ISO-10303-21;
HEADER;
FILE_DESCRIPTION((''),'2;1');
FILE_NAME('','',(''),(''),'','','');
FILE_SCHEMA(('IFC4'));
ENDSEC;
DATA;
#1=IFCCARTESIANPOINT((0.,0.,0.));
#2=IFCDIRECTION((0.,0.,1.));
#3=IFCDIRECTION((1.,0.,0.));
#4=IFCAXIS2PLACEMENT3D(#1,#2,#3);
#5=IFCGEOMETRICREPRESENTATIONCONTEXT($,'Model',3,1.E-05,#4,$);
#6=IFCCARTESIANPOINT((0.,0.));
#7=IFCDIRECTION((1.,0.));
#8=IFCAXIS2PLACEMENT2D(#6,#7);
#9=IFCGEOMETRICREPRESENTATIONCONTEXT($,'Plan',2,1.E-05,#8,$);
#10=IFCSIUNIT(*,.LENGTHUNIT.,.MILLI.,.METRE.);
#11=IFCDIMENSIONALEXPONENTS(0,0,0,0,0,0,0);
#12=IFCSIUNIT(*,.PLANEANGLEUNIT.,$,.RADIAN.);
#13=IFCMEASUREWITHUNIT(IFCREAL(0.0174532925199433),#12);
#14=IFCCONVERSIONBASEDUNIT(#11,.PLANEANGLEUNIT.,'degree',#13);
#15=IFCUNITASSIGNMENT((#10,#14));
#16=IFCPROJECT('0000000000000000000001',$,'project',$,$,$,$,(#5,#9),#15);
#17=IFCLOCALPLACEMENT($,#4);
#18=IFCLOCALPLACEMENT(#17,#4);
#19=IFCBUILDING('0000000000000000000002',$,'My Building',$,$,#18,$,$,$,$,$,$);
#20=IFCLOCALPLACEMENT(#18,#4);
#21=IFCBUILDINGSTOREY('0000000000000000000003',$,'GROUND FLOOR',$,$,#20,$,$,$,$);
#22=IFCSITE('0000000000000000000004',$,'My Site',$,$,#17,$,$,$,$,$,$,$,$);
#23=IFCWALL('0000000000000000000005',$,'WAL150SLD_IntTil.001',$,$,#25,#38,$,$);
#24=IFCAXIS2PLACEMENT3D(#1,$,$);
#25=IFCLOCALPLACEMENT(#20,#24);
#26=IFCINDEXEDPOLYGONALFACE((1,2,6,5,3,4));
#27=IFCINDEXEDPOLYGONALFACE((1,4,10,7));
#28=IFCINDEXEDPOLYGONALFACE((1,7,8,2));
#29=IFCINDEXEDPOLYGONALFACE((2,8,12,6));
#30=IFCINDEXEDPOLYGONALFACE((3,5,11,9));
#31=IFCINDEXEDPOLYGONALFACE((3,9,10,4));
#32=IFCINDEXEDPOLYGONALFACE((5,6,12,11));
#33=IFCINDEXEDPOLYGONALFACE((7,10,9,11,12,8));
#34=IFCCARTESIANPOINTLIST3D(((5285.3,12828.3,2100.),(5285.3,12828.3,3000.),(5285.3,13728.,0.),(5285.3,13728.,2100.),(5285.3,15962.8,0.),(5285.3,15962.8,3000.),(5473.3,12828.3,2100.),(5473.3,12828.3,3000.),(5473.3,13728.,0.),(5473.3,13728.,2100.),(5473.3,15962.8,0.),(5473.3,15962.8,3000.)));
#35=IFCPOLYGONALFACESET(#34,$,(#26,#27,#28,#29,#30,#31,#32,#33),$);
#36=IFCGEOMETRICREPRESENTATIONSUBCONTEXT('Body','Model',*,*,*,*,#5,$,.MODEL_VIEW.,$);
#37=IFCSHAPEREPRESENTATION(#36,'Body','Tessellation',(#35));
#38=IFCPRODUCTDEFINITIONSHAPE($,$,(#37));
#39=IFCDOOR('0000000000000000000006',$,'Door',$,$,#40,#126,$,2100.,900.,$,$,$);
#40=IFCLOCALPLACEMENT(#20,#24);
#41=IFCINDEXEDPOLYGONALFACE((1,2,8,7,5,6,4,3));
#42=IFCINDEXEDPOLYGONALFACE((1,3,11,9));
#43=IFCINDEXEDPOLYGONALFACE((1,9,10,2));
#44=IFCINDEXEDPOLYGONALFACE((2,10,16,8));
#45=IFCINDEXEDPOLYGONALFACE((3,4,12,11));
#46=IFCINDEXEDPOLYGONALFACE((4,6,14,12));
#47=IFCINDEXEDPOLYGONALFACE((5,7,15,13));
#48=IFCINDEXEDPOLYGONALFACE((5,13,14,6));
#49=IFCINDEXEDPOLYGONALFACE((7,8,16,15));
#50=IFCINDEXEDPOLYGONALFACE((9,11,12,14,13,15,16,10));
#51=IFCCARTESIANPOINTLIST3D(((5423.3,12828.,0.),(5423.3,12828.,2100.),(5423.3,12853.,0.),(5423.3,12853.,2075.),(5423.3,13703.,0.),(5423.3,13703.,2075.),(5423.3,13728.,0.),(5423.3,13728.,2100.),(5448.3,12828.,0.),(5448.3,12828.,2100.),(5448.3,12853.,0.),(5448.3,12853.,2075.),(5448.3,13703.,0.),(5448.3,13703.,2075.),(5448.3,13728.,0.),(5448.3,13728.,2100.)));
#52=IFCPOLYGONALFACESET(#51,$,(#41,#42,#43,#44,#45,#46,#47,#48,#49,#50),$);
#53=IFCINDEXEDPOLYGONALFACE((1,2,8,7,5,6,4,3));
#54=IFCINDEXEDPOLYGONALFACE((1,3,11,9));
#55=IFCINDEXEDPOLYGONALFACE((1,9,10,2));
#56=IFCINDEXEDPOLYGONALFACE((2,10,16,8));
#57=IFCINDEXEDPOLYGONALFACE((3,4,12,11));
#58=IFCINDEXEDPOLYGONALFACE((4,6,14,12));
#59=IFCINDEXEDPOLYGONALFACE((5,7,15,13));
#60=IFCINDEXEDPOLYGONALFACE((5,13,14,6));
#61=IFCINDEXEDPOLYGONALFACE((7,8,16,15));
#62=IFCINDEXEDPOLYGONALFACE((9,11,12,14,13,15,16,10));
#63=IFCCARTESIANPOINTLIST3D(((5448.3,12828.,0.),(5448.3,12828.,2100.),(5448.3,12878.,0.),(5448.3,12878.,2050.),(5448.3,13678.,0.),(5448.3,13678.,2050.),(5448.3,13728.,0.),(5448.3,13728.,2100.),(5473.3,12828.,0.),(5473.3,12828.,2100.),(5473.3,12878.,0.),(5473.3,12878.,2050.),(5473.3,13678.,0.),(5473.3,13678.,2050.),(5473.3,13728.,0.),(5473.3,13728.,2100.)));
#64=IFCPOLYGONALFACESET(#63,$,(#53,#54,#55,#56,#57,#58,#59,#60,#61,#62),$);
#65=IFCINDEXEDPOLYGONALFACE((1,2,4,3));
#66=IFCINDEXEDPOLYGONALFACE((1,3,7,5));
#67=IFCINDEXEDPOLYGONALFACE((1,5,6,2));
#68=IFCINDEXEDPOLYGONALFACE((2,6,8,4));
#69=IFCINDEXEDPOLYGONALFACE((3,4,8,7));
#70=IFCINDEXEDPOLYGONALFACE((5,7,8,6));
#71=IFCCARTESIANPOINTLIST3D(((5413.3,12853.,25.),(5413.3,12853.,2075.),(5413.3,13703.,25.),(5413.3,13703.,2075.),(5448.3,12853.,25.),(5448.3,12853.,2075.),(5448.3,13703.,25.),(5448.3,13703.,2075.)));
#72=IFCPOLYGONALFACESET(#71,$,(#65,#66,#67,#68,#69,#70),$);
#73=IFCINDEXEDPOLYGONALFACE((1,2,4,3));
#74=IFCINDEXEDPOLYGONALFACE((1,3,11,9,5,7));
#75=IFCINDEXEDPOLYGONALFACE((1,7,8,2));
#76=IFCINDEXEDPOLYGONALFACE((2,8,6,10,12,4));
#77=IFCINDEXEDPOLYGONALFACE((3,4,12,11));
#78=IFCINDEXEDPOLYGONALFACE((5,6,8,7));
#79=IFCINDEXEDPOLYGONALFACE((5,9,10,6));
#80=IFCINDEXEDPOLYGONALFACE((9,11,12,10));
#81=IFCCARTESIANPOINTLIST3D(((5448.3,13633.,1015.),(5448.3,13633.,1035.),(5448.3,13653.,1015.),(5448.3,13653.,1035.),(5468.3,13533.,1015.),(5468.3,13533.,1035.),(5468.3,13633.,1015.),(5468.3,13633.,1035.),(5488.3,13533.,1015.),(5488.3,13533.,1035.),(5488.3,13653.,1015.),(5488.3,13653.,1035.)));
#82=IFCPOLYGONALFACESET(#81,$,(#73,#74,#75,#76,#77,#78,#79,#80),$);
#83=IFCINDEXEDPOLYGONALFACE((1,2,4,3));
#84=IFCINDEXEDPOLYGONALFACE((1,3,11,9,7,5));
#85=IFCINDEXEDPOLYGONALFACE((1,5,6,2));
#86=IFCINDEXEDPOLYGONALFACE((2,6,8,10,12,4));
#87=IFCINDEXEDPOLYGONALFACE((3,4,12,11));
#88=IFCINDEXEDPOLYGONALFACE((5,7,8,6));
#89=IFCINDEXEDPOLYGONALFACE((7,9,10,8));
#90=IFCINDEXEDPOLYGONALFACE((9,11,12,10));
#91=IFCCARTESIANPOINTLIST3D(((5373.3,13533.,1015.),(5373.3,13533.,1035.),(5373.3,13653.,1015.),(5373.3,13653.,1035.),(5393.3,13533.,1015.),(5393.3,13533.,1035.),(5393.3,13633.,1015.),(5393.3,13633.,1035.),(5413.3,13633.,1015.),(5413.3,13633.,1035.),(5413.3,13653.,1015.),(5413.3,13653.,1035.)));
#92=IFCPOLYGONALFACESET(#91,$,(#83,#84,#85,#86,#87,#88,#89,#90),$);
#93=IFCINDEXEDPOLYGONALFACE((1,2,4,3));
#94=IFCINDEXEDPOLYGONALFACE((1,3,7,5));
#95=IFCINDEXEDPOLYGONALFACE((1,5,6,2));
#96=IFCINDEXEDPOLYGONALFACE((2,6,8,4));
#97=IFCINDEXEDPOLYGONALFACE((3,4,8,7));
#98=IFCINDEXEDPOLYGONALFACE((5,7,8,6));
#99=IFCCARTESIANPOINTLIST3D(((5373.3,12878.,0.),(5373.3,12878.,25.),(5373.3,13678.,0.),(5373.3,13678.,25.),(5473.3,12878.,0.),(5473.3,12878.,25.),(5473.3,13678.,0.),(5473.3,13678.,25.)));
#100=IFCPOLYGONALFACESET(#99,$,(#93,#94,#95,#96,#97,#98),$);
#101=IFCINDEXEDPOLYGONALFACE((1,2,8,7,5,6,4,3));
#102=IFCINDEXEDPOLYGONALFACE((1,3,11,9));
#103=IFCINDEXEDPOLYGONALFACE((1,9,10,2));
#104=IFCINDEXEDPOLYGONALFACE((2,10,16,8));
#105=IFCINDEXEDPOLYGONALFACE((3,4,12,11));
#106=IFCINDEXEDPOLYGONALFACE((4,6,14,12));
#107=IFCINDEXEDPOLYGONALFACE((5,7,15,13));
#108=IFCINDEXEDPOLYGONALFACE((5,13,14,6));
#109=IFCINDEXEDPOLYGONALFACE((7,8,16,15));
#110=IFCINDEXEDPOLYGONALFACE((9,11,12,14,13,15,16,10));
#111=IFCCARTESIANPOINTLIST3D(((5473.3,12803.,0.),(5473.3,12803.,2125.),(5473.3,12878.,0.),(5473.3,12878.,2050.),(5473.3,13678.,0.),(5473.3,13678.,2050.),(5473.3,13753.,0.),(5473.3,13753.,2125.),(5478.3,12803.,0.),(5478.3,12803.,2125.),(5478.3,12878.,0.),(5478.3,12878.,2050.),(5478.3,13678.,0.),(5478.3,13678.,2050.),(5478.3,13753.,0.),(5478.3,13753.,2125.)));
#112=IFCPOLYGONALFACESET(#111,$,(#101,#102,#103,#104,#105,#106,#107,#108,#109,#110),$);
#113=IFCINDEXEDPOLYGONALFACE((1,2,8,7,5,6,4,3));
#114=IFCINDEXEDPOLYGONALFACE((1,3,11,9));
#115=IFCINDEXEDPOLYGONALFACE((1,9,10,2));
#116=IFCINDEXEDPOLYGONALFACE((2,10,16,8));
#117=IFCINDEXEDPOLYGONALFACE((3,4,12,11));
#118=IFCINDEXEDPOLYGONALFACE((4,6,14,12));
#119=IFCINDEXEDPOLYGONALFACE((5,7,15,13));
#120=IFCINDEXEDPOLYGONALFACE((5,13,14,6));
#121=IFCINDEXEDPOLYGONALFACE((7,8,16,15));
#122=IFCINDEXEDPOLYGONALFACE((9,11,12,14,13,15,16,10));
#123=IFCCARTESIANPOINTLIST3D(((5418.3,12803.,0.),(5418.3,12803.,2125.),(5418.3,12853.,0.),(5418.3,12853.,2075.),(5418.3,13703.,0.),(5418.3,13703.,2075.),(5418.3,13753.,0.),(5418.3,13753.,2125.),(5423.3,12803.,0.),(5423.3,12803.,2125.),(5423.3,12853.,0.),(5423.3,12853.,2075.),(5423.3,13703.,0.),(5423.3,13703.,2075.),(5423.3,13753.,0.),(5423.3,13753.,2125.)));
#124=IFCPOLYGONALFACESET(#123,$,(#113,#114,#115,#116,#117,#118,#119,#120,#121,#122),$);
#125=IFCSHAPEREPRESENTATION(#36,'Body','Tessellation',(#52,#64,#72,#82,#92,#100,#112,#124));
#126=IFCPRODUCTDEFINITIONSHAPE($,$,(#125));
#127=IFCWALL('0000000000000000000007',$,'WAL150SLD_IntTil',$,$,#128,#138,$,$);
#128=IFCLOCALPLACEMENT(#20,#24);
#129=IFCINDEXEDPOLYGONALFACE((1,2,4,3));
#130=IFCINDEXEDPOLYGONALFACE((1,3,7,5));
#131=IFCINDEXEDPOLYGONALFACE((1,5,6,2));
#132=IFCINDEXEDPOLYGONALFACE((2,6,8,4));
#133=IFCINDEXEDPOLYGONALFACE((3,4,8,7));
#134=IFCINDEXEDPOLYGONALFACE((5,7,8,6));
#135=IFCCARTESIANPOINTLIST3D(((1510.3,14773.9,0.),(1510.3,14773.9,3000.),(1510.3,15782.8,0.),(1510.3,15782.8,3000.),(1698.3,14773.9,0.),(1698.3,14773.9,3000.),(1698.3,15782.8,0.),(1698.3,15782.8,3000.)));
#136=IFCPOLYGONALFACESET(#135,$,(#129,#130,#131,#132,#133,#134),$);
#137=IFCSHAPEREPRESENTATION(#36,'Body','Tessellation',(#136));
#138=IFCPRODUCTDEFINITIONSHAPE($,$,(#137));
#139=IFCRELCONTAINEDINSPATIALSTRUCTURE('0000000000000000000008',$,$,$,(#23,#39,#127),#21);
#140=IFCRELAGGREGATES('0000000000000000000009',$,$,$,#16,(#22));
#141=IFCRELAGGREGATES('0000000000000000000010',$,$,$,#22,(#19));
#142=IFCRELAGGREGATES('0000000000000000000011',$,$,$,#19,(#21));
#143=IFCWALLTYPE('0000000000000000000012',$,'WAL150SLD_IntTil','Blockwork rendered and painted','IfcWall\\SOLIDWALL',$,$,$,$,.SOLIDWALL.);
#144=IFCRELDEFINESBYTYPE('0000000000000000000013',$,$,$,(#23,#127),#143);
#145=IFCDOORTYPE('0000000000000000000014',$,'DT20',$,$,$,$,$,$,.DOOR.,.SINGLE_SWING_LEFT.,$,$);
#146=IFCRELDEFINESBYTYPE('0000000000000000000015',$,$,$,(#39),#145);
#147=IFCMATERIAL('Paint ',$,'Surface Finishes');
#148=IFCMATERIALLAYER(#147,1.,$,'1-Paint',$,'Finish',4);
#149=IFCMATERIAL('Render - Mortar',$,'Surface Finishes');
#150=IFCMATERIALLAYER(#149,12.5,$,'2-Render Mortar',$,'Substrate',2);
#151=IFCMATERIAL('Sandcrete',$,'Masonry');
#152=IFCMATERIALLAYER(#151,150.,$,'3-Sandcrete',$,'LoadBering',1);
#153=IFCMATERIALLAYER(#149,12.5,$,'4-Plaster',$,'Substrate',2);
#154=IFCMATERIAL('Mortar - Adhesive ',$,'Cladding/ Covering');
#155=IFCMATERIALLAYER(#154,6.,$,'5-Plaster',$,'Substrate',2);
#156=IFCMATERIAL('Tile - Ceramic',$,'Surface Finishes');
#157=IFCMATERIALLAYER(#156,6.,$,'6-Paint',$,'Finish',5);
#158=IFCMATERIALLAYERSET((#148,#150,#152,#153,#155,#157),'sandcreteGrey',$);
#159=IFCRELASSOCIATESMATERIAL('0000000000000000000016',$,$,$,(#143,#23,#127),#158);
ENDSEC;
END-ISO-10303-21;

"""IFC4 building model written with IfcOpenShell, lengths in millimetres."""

from ifc_helpers import new_model, entity, si_unit, converted_unit, frame, origin_with_axes, origin_2d_with_axis, place, context, subcontext, project, spatial, line, indexed_curve, outline, extrude, shape, source, transform, mapped, material, layer, layer_set, layer_usage, type_object, type_shapes, element, fill, save


model = new_model("IFC4")

# Units and contexts
model_context = context("Model", 3, precision=1e-05, world=origin_with_axes())
plan_context = context("Plan", 2, precision=1e-05, world=origin_2d_with_axis())
body_context_1 = subcontext(model_context, "Body", "Model", "MODEL_VIEW")
body_context_2 = subcontext(plan_context, "Body", "Plan", "PLAN_VIEW")
ifc_project = project(units=[si_unit("LENGTHUNIT", "METRE", prefix="MILLI"), converted_unit("PLANEANGLEUNIT", "degree", entity("IfcReal", 0.0174532925199433), si_unit("PLANEANGLEUNIT", "RADIAN"), dimensions=[0, 0, 0, 0, 0, 0, 0])], contexts=[model_context, plan_context])

# Site, building, storey
site_placement = place(None, origin_with_axes())
site = spatial("IfcSite", under=ifc_project, at=site_placement, Name="My Site")
building_placement = place(site_placement, origin_with_axes())
building = spatial("IfcBuilding", under=site, at=building_placement, Name="My Building")
storey_placement = place(building_placement, origin_with_axes())
storey = spatial("IfcBuildingStorey", under=building, at=storey_placement, Name="GROUND FLOOR")

# Shared definitions
ifc_material_1 = material(Name="Paint ", Category="Surface Finishes")
ifc_material_2 = material(Name="Render - Mortar", Category="Surface Finishes")
ifc_material_3 = material(Name="Sandcrete", Category="Masonry")

# Shared definitions
ifc_material_4 = material(Name="Mortar - Adhesive ", Category="Cladding/ Covering")
ifc_material_5 = material(Name="Tile - Ceramic", Category="Surface Finishes")

# Shared definitions
ifc_layer_1 = layer(ifc_material_1, 1.0, Name="1-Paint", Category="Finish", Priority=4)
ifc_layer_2 = layer(ifc_material_2, 12.5, Name="2-Render Mortar", Category="Substrate", Priority=2)
ifc_layer_3 = layer(ifc_material_3, 150.0, Name="3-Sandcrete", Category="LoadBering", Priority=1)
ifc_layer_4 = layer(ifc_material_2, 12.5, Name="4-Plaster", Category="Substrate", Priority=2)
ifc_layer_5 = layer(ifc_material_4, 6.0, Name="5-Plaster", Category="Substrate", Priority=2)
ifc_layer_6 = layer(ifc_material_5, 6.0, Name="6-Paint", Category="Finish", Priority=5)
ifc_layer_set_1 = layer_set([ifc_layer_1, ifc_layer_2, ifc_layer_3, ifc_layer_4, ifc_layer_5, ifc_layer_6], Name="sandcreteGrey")
wall_type_1 = type_object("IfcWallType", Name="WAL150SLD_IntTil", Description="Blockwork rendered and painted", ApplicableOccurrence="IfcWall\\SOLIDWALL", PredefinedType="SOLIDWALL", material=ifc_layer_set_1)

# Wall, opening, door
ifc_layer_usage_1 = layer_usage(ifc_layer_set_1, "AXIS2", "POSITIVE", 0.0)
wall_1_placement = place(storey_placement, frame((5473.3, 12828.3, 0.0), z_axis=(0.0, 0.0, 1.0), x_axis=(0.000001, 1.0, 0.0)))
wall_1 = element("IfcWall", 1, at=wall_1_placement, inside=storey, type_object=wall_type_1, material=ifc_layer_usage_1, Name="WAL150SLD_IntTil.001", context=body_context_1, shape_type="SweptSolid", body=[
    extrude(outline(indexed_curve([(0.0, 0.0), (0.0, 188.0), (3134.5, 188.0), (3134.5, 0.0), (0.0, 0.0)], self_intersect=False)), origin_with_axes(), (0.0, 0.0, 1.0), 3000.0),
])
shared_shape_1 = source(origin_with_axes(), body_context_1, "Body", "SweptSolid", [
    extrude(outline(indexed_curve([(0.0, 0.0), (900.0, 0.0), (900.0, 2100.0), (0.0, 2100.0)], segments=[line(1, 2, 3, 4, 1)])), frame((0.0, -100.0, 0.0), z_axis=(0.0, -1.0, 0.0), x_axis=(1.0, 0.0, 0.0)), (0.0, 0.0, -1.0), 380.0),
])
opening_1_placement = place(wall_1_placement, frame((-0.3, 0.0, 0.0), z_axis=(0.0, 0.0, 1.0), x_axis=(1.0, 0.0, 0.0)))
opening_1 = element("IfcOpeningElement", 2, at=opening_1_placement, cuts=wall_1, PredefinedType="OPENING", context=body_context_1, shape_type="MappedRepresentation", body=[
    mapped(shared_shape_1, transform((0.0, 0.0, 0.0), x_axis=(1.0, 0.0, 0.0), y_axis=(0.0, 1.0, 0.0), z_axis=(0.0, 0.0, 1.0), scale=1.0)),
])
door_type_1 = type_object("IfcDoorType", Name="DT20", OperationType="SINGLE_SWING_LEFT", PredefinedType="DOOR")
shared_shape_2 = source(origin_with_axes(), body_context_1, "Body", "SweptSolid", [
    extrude(outline(indexed_curve([(0.0, 0.0), (0.0, 2100.0), (900.0, 2100.0), (900.0, 0.0), (875.0, 0.0), (875.0, 2075.0), (25.0, 2075.0), (25.0, 0.0)], segments=[line(1, 2, 3, 4, 5, 6, 7, 8, 1)])), frame((0.0, 25.0, 0.0), z_axis=(0.0, -1.0, 0.0), x_axis=(1.0, 0.0, 0.0)), (0.0, 0.0, -1.0), 25.0),
    extrude(outline(indexed_curve([(0.0, 0.0), (0.0, 2100.0), (900.0, 2100.0), (900.0, 0.0), (850.0, 0.0), (850.0, 2050.0), (50.0, 2050.0), (50.0, 0.0)], segments=[line(1, 2, 3, 4, 5, 6, 7, 8, 1)])), frame((0.0, 0.0, 0.0), z_axis=(0.0, -1.0, 0.0), x_axis=(1.0, 0.0, 0.0)), (0.0, 0.0, -1.0), 25.0),
    extrude(outline(indexed_curve([(0.0, 0.0), (850.0, 0.0), (850.0, 35.0), (0.0, 35.0)], segments=[line(1, 2, 3, 4, 1)])), frame((25.0, 25.0, 25.0), z_axis=(0.0, 0.0, 1.0), x_axis=(1.0, 0.0, 0.0)), (0.0, 0.0, 1.0), 2050.0),
    extrude(outline(indexed_curve([(0.0, 0.0), (0.0, -40.0), (-120.0, -40.0), (-120.0, -20.0), (-20.0, -20.0), (-20.0, 0.0)], segments=[line(1, 2, 3, 4, 5, 6, 1)])), frame((825.0, 25.0, 1015.0), z_axis=(0.0, 0.0, 1.0), x_axis=(1.0, 0.0, 0.0)), (0.0, 0.0, 1.0), 20.0),
    extrude(outline(indexed_curve([(0.0, 0.0), (0.0, 40.0), (-120.0, 40.0), (-120.0, 20.0), (-20.0, 20.0), (-20.0, 0.0)], segments=[line(1, 2, 3, 4, 5, 6, 1)])), frame((825.0, 60.0, 1015.0), z_axis=(0.0, 0.0, 1.0), x_axis=(1.0, 0.0, 0.0)), (0.0, 0.0, 1.0), 20.0),
    extrude(outline(indexed_curve([(0.0, 0.0), (800.0, 0.0), (800.0, 100.0), (0.0, 100.0)], segments=[line(1, 2, 3, 4, 1)])), frame((50.0, 0.0, 0.0), z_axis=(0.0, 0.0, 1.0), x_axis=(1.0, 0.0, 0.0)), (0.0, 0.0, 1.0), 25.0),
    extrude(outline(indexed_curve([(0.0, 0.0), (0.0, 2125.0), (950.0, 2125.0), (950.0, 0.0), (875.0, 0.0), (875.0, 2050.0), (75.0, 2050.0), (75.0, 0.0)], segments=[line(1, 2, 3, 4, 5, 6, 7, 8, 1)])), frame((-25.0, -5.0, 0.0), z_axis=(0.0, -1.0, 0.0), x_axis=(1.0, 0.0, 0.0)), (0.0, 0.0, -1.0), 5.0),
    extrude(outline(indexed_curve([(0.0, 0.0), (0.0, 2125.0), (950.0, 2125.0), (950.0, 0.0), (900.0, 0.0), (900.0, 2075.0), (50.0, 2075.0), (50.0, 0.0)], segments=[line(1, 2, 3, 4, 5, 6, 7, 8, 1)])), frame((-25.0, 50.0, 0.0), z_axis=(0.0, -1.0, 0.0), x_axis=(1.0, 0.0, 0.0)), (0.0, 0.0, -1.0), 5.0),
])
shared_shape_3 = source(origin_with_axes(), body_context_2, "Body", "Curve2D", [
    entity("IfcIndexedPolyCurve", entity("IfcCartesianPointList2D", [[0.0, 0.0], [0.0, 50.0], [25.0, 50.0], [25.0, 25.0], [50.0, 25.0], [50.0, 0.0]]), [entity("IfcLineIndex", [1, 2, 3, 4, 5, 6, 1])]),
    entity("IfcIndexedPolyCurve", entity("IfcCartesianPointList2D", [[900.0, 0.0], [900.0, 50.0], [875.0, 50.0], [875.0, 25.0], [850.0, 25.0], [850.0, 0.0]]), [entity("IfcLineIndex", [1, 2, 3, 4, 5, 6, 1])]),
    entity("IfcTrimmedCurve", entity("IfcEllipse", entity("IfcAxis2Placement2D", entity("IfcCartesianPoint", [60.0, 50.0]), entity("IfcDirection", [1.0, 0.0])), 815.0, 850.0), [entity("IfcCartesianPoint", [875.0, 50.0])], [entity("IfcCartesianPoint", [60.0, 900.0])], True, "CARTESIAN"),
    entity("IfcIndexedPolyCurve", entity("IfcCartesianPointList2D", [[25.0, 50.0], [60.0, 50.0], [60.0, 900.0], [25.0, 900.0]]), [entity("IfcLineIndex", [1, 2, 3, 4, 1])]),
])
type_shapes(door_type_1, [shared_shape_2, shared_shape_3])
door_1_placement = place(opening_1_placement, frame((0.0, 0.0, 0.0), z_axis=(0.0, 0.0, 1.0), x_axis=(1.0, 0.0, 0.0)))
door_1 = element("IfcDoor", 3, at=door_1_placement, inside=storey, type_object=door_type_1, Name="Door", OverallHeight=2100.0, OverallWidth=900.0, shapes=[
    shape(body_context_1, "Body", "MappedRepresentation", [mapped(shared_shape_2, transform((0.0, 0.0, 0.0), x_axis=(1.0, 0.0, 0.0), y_axis=(0.0, 1.0, 0.0), z_axis=(0.0, 0.0, 1.0), scale=1.0))]),
    shape(body_context_2, "Body", "MappedRepresentation", [mapped(shared_shape_3, transform((0.0, 0.0, 0.0), x_axis=(1.0, 0.0, 0.0), y_axis=(0.0, 1.0, 0.0), z_axis=(0.0, 0.0, 1.0), scale=1.0))]),
])
fill(opening_1, door_1)

# Wall
ifc_layer_usage_2 = layer_usage(ifc_layer_set_1, "AXIS2", "POSITIVE", 0.0)
wall_2_placement = place(storey_placement, frame((1510.3, 15782.8, 0.0), z_axis=(0.0, 0.0, 1.0), x_axis=(-0.000001, -1.0, 0.0)))
element("IfcWall", 4, at=wall_2_placement, inside=storey, type_object=wall_type_1, material=ifc_layer_usage_2, Name="WAL150SLD_IntTil", context=body_context_1, shape_type="SweptSolid", body=[
    extrude(outline(indexed_curve([(0.0, 0.0), (0.0, 188.0), (1008.9, 188.0), (1008.9, 0.0), (0.0, 0.0)], self_intersect=False)), origin_with_axes(), (0.0, 0.0, 1.0), 3000.0),
])

save(model, "model.ifc")
